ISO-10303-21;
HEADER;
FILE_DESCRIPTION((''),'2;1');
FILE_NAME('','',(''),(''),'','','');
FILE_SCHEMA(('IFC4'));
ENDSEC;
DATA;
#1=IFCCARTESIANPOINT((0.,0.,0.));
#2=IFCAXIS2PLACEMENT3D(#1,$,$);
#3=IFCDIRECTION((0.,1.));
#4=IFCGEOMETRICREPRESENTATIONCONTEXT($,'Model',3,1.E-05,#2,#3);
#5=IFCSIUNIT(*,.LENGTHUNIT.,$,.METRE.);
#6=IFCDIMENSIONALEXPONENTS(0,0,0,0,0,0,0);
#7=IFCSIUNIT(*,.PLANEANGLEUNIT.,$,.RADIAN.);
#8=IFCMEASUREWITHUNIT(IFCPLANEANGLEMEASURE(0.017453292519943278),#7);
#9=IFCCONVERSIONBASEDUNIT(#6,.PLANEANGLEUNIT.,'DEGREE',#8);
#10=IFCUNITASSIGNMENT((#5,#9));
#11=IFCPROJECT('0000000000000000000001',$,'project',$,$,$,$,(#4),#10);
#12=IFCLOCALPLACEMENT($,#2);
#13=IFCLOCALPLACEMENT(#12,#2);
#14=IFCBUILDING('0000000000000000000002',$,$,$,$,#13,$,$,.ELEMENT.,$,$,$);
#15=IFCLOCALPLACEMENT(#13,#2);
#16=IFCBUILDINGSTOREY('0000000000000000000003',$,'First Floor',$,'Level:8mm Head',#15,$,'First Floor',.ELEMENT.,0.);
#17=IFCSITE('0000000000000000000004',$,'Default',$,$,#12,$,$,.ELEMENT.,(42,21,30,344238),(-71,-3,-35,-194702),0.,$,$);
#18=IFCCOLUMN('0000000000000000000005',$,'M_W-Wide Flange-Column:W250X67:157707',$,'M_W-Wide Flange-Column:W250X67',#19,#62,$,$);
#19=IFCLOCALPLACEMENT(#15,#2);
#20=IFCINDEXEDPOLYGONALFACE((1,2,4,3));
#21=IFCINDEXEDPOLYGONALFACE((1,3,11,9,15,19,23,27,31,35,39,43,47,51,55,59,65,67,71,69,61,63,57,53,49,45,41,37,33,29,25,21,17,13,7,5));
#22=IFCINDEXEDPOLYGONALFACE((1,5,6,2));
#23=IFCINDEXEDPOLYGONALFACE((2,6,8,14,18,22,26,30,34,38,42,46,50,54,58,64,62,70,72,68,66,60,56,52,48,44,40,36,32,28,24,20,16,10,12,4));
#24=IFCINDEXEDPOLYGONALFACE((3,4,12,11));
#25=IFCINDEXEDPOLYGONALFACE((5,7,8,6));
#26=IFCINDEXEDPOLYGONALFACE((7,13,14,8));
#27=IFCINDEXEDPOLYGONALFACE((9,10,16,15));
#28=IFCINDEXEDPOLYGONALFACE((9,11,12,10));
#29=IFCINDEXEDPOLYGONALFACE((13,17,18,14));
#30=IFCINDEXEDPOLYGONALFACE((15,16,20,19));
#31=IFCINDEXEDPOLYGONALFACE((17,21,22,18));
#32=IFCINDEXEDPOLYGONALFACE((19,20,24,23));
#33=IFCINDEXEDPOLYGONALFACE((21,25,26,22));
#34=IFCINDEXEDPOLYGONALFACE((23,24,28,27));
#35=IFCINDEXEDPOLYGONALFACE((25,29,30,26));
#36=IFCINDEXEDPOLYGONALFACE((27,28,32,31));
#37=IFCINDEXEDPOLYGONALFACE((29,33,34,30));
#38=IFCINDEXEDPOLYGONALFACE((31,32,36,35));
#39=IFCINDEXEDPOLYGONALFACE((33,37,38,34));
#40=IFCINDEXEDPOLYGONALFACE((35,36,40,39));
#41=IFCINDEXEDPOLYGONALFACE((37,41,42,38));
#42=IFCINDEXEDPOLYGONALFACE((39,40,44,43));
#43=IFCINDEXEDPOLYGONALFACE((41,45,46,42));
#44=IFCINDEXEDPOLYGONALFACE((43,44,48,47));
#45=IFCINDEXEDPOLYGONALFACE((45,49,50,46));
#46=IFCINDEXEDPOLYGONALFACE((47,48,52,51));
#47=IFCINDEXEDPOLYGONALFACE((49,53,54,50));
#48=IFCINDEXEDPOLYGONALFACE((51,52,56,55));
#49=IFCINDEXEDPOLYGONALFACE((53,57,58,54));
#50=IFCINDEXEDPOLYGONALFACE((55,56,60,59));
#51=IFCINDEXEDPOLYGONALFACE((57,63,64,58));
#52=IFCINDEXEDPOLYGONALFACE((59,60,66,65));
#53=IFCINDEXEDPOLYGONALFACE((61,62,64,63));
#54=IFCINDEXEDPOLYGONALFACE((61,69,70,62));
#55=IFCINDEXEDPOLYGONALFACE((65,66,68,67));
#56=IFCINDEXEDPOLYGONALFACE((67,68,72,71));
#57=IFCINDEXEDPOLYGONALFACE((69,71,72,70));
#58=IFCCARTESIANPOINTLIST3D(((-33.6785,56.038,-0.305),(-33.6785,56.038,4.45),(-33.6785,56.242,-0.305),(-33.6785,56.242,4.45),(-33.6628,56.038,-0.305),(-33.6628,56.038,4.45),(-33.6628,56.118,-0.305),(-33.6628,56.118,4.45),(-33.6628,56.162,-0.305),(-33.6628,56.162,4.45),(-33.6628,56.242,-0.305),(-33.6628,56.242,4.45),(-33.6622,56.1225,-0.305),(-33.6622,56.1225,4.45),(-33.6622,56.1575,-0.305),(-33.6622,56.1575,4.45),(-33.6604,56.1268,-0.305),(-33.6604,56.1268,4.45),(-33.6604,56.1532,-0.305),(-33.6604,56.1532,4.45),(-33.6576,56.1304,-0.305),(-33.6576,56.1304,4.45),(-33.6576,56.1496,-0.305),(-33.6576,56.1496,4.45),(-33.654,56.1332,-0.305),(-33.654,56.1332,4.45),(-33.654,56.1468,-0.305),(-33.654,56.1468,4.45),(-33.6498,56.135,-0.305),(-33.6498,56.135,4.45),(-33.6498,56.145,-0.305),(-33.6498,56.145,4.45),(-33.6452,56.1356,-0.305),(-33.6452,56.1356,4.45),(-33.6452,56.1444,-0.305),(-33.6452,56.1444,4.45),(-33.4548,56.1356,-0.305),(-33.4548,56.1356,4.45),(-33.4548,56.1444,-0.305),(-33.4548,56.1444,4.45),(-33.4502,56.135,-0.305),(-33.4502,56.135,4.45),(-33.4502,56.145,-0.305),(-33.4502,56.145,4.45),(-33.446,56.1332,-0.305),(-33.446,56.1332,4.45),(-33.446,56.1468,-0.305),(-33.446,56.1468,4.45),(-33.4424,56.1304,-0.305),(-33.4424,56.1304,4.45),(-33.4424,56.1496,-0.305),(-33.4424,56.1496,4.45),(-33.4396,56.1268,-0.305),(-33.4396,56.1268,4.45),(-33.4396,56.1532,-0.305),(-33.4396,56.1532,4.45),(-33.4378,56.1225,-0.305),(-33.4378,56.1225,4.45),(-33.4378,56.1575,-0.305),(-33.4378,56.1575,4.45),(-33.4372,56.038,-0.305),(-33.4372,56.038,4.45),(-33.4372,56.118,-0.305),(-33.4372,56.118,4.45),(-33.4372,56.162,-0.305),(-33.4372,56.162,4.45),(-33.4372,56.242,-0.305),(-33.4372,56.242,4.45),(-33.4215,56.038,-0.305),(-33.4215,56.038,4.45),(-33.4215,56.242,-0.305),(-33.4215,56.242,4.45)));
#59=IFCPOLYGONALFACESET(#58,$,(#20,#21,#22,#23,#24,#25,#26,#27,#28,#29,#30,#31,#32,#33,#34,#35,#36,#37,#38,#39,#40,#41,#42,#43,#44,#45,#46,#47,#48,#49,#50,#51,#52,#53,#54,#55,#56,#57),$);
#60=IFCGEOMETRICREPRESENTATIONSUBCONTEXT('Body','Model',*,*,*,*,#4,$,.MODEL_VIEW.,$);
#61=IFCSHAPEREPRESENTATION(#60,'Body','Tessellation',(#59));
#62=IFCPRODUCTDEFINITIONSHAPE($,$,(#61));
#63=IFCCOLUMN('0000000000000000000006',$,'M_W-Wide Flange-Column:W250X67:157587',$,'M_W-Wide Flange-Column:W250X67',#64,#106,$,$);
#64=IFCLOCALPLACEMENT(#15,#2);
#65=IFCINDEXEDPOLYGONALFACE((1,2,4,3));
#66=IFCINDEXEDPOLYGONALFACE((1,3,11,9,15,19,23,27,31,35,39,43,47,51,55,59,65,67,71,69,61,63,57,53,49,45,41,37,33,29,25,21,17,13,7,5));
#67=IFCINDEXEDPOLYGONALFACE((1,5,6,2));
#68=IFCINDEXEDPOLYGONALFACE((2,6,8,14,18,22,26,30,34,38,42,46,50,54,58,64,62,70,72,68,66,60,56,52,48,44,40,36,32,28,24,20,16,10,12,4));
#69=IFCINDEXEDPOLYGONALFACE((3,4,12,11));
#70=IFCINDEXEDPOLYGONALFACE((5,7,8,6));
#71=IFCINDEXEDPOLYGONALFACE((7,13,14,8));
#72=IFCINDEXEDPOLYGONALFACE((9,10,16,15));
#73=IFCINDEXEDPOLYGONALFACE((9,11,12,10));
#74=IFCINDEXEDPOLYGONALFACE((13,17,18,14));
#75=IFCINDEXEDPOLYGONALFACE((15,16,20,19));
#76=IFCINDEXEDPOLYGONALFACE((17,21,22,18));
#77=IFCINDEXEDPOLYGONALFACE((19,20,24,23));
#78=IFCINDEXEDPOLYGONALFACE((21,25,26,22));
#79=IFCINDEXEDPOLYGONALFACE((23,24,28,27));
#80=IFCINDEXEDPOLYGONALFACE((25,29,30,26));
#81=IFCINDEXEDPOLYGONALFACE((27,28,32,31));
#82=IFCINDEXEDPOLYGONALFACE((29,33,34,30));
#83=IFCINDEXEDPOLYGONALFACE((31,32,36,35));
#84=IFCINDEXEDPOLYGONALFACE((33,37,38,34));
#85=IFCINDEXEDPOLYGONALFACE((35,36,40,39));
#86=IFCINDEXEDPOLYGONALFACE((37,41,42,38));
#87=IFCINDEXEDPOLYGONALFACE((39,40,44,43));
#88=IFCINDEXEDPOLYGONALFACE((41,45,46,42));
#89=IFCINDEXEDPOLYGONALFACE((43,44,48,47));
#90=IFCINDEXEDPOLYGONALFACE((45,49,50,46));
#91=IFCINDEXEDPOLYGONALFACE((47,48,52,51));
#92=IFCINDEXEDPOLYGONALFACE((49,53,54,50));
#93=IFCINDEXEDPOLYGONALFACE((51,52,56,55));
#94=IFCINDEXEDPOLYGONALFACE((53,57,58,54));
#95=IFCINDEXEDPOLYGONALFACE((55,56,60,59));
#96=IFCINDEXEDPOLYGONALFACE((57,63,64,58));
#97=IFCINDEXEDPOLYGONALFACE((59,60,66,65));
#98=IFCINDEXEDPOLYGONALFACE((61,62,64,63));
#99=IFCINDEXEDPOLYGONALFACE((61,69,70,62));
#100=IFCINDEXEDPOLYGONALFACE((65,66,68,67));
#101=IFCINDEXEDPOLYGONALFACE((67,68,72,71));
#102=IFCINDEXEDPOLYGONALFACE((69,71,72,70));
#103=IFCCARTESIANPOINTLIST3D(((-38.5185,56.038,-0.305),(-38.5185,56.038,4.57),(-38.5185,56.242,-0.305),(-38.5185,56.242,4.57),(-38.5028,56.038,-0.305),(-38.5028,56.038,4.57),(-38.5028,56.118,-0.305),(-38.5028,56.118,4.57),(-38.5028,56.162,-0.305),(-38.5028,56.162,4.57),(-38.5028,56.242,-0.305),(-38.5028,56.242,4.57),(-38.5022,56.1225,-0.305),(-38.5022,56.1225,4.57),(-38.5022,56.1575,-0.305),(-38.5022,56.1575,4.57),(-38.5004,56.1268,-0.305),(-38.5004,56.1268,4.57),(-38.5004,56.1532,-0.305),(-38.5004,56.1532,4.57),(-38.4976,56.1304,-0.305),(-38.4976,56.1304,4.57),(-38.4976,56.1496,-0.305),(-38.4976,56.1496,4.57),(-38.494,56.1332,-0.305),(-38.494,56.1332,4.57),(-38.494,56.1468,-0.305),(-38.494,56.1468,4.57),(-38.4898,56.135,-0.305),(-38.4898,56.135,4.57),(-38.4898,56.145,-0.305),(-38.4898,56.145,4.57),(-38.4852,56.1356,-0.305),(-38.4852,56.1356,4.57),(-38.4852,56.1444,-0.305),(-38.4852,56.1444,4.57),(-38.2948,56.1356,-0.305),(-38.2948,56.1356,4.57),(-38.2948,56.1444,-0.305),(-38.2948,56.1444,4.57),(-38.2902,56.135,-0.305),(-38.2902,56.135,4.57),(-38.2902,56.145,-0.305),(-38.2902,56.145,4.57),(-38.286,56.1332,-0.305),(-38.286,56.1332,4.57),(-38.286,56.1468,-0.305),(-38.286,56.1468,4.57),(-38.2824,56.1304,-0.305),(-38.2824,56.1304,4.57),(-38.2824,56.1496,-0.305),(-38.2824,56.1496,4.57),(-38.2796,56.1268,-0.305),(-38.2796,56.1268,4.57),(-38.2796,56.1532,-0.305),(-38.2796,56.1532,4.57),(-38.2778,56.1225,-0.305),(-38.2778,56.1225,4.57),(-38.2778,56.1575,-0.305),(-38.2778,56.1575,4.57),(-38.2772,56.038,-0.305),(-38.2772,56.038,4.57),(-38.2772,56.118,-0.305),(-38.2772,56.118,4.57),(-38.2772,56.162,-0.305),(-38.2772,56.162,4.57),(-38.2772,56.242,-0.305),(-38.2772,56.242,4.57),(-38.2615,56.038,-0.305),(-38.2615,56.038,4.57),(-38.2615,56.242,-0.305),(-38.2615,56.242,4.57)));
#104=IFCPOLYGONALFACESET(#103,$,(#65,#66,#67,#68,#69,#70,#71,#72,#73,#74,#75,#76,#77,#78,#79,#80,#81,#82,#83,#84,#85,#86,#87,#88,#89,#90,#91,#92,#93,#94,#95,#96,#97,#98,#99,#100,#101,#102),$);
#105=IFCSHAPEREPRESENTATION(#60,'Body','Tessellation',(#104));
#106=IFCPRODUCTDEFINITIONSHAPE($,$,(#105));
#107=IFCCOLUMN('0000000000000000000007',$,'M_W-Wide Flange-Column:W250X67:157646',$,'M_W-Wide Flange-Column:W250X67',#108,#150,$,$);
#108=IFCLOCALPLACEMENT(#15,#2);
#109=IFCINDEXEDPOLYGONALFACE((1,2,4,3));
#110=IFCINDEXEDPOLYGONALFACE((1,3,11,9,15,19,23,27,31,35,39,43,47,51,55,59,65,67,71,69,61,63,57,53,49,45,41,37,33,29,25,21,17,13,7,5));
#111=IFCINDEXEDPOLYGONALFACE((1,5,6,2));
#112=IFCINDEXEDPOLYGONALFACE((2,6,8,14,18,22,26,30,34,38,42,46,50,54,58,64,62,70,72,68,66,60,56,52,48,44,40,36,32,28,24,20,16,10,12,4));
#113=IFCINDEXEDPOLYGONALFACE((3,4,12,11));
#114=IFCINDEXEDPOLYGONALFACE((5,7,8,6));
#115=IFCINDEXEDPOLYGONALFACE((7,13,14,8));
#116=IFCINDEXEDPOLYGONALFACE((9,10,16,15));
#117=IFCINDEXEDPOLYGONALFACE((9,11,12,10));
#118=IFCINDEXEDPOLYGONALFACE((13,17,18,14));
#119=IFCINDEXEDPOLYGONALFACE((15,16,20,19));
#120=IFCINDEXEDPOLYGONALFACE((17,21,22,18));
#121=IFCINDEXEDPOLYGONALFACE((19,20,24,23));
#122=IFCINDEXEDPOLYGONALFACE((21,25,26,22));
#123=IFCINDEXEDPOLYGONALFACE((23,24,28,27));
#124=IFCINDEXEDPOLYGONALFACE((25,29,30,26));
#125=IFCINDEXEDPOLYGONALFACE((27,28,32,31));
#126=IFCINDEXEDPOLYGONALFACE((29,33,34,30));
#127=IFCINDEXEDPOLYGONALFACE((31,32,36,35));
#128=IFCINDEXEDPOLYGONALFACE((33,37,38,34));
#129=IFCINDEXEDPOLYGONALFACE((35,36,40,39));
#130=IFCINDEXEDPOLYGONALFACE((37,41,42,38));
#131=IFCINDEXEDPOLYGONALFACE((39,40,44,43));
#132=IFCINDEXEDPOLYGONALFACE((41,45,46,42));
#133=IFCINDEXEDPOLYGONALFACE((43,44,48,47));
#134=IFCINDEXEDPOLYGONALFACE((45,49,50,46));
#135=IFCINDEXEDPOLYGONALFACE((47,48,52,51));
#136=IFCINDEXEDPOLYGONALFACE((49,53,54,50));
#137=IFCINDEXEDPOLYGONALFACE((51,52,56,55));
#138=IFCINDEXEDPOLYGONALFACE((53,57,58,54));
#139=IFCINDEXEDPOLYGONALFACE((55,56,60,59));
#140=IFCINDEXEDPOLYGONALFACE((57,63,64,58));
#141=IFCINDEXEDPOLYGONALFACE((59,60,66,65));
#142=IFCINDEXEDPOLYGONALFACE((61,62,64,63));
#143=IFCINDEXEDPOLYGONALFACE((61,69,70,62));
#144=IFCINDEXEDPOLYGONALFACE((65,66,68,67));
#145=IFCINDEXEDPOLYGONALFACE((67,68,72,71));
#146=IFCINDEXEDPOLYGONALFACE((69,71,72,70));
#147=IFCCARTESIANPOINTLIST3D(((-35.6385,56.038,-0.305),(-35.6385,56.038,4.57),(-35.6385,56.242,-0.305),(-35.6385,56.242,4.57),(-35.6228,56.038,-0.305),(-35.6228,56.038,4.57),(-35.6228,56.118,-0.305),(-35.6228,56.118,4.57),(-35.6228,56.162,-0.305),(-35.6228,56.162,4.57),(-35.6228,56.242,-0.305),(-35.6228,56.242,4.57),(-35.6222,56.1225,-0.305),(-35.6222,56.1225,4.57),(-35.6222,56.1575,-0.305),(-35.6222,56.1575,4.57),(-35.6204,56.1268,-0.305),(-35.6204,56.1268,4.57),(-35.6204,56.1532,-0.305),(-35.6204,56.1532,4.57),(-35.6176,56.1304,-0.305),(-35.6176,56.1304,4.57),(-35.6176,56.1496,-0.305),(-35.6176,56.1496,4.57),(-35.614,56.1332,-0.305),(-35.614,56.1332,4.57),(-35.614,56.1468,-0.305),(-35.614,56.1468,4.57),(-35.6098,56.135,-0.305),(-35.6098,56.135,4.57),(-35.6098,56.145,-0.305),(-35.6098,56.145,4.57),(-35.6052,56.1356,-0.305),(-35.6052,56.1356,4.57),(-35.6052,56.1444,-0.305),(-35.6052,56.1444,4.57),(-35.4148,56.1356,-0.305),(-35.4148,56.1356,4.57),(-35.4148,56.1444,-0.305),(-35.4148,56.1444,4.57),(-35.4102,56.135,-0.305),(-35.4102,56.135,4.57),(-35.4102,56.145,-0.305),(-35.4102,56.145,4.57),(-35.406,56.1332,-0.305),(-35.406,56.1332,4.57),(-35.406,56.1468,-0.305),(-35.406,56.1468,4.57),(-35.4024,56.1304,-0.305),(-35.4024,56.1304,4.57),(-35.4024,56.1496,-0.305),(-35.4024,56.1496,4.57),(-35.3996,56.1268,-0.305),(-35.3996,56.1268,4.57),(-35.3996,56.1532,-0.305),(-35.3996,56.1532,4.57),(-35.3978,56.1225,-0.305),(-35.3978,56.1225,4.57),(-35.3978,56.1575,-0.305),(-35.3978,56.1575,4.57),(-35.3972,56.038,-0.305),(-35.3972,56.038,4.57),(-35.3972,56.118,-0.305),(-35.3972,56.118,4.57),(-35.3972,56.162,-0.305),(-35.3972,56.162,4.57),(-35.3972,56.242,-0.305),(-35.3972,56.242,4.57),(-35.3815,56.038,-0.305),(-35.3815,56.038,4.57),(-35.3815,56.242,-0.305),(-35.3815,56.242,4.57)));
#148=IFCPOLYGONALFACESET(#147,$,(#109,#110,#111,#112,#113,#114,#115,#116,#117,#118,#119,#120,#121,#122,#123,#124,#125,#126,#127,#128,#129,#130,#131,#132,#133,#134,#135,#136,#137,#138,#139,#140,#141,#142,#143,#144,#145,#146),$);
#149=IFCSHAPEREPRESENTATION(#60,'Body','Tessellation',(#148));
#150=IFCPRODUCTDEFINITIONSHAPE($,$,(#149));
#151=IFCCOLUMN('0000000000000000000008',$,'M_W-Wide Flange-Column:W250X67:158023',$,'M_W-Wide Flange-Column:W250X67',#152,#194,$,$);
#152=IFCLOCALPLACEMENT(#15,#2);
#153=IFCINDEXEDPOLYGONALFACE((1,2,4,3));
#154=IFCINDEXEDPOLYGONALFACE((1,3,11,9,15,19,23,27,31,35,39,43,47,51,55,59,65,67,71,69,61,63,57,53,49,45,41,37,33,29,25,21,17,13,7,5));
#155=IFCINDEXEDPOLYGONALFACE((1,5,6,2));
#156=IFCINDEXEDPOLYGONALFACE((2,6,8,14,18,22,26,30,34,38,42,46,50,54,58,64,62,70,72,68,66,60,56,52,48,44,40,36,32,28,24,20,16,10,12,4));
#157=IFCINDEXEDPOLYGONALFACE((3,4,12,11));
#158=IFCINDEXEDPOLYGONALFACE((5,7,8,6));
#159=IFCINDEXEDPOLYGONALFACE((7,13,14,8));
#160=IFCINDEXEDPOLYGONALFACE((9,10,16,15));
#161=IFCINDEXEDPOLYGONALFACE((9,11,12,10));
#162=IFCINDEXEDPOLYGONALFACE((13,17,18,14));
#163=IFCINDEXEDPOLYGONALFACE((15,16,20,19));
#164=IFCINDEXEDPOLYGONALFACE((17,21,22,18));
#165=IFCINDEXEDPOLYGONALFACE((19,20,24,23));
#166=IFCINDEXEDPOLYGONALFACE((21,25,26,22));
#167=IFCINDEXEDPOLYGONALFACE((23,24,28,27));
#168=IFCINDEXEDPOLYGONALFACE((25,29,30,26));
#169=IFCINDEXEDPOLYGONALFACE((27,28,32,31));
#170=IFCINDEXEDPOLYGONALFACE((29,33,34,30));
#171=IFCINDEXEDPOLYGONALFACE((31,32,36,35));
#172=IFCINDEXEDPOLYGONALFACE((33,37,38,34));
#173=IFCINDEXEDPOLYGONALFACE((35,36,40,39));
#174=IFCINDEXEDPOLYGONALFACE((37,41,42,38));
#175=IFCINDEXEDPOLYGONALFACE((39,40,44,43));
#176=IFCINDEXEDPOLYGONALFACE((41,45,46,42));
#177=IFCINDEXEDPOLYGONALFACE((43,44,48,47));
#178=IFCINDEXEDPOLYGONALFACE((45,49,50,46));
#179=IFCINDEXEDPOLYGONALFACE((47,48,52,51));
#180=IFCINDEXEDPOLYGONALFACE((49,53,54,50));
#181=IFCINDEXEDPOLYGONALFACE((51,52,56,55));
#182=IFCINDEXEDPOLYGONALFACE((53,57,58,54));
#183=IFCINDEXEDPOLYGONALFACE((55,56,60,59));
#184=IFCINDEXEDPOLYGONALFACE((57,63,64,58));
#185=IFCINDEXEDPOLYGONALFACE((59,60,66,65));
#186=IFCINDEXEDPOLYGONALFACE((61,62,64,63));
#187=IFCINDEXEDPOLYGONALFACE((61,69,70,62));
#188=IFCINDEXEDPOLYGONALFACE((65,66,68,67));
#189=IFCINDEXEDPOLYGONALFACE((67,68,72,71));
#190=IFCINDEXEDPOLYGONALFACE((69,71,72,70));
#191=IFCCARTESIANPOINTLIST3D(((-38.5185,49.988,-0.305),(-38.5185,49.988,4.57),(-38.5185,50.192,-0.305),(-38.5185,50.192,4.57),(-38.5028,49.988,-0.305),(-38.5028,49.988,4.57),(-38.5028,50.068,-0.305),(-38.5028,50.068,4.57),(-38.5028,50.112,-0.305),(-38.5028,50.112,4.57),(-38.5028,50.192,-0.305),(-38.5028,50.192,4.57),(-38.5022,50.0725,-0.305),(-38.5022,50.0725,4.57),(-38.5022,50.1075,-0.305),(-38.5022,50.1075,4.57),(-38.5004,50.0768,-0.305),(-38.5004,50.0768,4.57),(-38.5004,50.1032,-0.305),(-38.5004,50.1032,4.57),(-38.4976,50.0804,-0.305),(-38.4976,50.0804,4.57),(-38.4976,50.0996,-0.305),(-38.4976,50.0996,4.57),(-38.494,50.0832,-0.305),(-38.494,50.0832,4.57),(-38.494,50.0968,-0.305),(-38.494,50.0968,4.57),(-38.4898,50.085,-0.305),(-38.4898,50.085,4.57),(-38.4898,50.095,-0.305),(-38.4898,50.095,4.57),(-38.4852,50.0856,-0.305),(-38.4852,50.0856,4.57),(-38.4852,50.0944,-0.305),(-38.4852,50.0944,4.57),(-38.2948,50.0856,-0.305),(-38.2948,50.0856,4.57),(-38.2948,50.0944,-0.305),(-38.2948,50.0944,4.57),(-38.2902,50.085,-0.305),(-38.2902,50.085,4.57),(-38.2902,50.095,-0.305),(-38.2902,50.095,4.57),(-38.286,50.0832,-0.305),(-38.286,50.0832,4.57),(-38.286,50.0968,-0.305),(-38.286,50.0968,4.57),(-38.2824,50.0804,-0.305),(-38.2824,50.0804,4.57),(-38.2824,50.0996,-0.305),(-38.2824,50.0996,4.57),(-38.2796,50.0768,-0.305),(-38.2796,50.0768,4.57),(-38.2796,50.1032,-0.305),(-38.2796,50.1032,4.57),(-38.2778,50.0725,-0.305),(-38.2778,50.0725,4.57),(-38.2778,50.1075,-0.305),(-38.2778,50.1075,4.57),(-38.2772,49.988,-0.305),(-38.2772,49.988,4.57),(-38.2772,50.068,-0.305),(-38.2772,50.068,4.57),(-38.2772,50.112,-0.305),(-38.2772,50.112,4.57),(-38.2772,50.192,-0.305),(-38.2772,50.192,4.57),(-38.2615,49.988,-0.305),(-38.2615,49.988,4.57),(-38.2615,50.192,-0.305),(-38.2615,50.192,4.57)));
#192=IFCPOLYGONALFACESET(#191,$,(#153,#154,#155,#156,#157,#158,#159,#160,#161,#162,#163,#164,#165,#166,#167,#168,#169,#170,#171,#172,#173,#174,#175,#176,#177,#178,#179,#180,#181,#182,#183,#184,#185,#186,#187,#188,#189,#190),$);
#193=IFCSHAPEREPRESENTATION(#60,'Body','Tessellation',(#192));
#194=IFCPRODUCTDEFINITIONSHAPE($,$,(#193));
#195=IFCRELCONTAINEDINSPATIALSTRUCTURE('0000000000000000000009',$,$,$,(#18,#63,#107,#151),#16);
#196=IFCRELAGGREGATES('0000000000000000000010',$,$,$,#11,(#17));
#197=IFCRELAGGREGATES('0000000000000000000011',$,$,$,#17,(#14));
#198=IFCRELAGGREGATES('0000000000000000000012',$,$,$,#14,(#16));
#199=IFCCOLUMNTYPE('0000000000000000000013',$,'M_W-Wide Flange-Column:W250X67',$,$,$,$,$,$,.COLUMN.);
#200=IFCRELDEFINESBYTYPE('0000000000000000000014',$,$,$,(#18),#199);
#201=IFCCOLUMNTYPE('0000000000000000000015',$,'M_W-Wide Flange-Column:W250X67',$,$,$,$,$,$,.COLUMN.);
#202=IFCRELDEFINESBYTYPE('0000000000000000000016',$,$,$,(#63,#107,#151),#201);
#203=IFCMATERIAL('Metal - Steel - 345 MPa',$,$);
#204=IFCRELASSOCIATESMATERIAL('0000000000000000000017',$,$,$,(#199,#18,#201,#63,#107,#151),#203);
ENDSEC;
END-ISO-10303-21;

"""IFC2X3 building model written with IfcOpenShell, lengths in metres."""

from ifc_helpers import new_model, entity, si_unit, converted_unit, direction, frame, frame_2d, origin, place, context, subcontext, project, spatial, i_section, extrude, source, transform, mapped, material, type_object, type_shapes, element, save


model = new_model("IFC2X3")

# Units and contexts
model_context = context("Model", 3, precision=1e-05, world=origin(), true_north=direction((0.0, 1.0)))
body_context = subcontext(model_context, "Body", "Model", "MODEL_VIEW")
ifc_project = project(units=[si_unit("LENGTHUNIT", "METRE"), converted_unit("PLANEANGLEUNIT", "DEGREE", entity("IfcPlaneAngleMeasure", 0.017453292519943278), si_unit("PLANEANGLEUNIT", "RADIAN"), dimensions=[0, 0, 0, 0, 0, 0, 0])], contexts=[model_context])

# Site, building, storey
site_placement = place(None, origin())
site = spatial("IfcSite", under=ifc_project, at=site_placement, Name="Default", CompositionType="ELEMENT", RefLatitude=(42, 21, 30, 344238), RefLongitude=(-71, -3, -35, -194702), RefElevation=0.0)
building_placement = place(site_placement, origin())
building = spatial("IfcBuilding", under=site, at=building_placement, CompositionType="ELEMENT")
storey_placement = place(building_placement, origin())
storey = spatial("IfcBuildingStorey", under=building, at=storey_placement, Name="First Floor", ObjectType="Level:8mm Head", LongName="First Floor", CompositionType="ELEMENT", Elevation=0.0)

# Columns
ifc_material_1 = material(Name="Metal - Steel - 345 MPa")
column_type_1 = type_object("IfcColumnType", Name="M_W-Wide Flange-Column:W250X67", PredefinedType="COLUMN", material=ifc_material_1)
shared_shape_1 = source(origin(), body_context, "Body", "SweptSolid", [
    extrude(i_section(OverallWidth=0.204, OverallDepth=0.257, WebThickness=0.0089, FlangeThickness=0.0157, FilletRadius=0.0176, at=frame_2d((0.0, 0.0), x_axis=(1.0, 0.0))), frame((0.0, 0.0, -0.305), z_axis=(0.0, 0.0, 1.0), x_axis=(-1.0, 0.0, 0.0)), (0.0, 0.0, 1.0), 4.755),
])
type_shapes(column_type_1, [shared_shape_1])
column_1_placement = place(storey_placement, frame((-33.55, 56.14, 0.0), z_axis=(0.0, 0.0, 1.0), x_axis=(0.0, 1.0, 0.0)))
element("IfcColumn", 1, at=column_1_placement, inside=storey, type_object=column_type_1, material=ifc_material_1, Name="M_W-Wide Flange-Column:W250X67:157707", ObjectType="M_W-Wide Flange-Column:W250X67", context=body_context, shape_type="MappedRepresentation", body=[
    mapped(shared_shape_1, transform((0.0, 0.0, 0.0), scale=1.0)),
])
column_type_2 = type_object("IfcColumnType", Name="M_W-Wide Flange-Column:W250X67", PredefinedType="COLUMN", material=ifc_material_1)
shared_shape_2 = source(origin(), body_context, "Body", "SweptSolid", [
    extrude(i_section(OverallWidth=0.204, OverallDepth=0.257, WebThickness=0.0089, FlangeThickness=0.0157, FilletRadius=0.0176, at=frame_2d((0.0, 0.0), x_axis=(1.0, 0.0))), frame((0.0, 0.0, -0.305), z_axis=(0.0, 0.0, 1.0), x_axis=(-1.0, 0.0, 0.0)), (0.0, 0.0, 1.0), 4.875),
])
type_shapes(column_type_2, [shared_shape_2])
for number, where, z_axis, x_axis, name in (
    (2, (-38.39, 56.14, 0.0), (0.0, 0.0, 1.0), (0.0, 1.0, 0.0), "M_W-Wide Flange-Column:W250X67:157587"),
    (3, (-35.51, 56.14, 0.0), (0.0, 0.0, 1.0), (0.0, 1.0, 0.0), "M_W-Wide Flange-Column:W250X67:157646"),
    (4, (-38.39, 50.09, 0.0), (0.0, 0.0, 1.0), (0.0, 1.0, 0.0), "M_W-Wide Flange-Column:W250X67:158023"),
):
    element("IfcColumn", number, at=place(storey_placement, frame(where, z_axis=z_axis, x_axis=x_axis)), inside=storey, type_object=column_type_2, material=ifc_material_1, Name=name, ObjectType="M_W-Wide Flange-Column:W250X67", context=body_context, shape_type="MappedRepresentation", body=[
        mapped(shared_shape_2, transform((0.0, 0.0, 0.0), scale=1.0)),
    ])

save(model, "model.ifc")
